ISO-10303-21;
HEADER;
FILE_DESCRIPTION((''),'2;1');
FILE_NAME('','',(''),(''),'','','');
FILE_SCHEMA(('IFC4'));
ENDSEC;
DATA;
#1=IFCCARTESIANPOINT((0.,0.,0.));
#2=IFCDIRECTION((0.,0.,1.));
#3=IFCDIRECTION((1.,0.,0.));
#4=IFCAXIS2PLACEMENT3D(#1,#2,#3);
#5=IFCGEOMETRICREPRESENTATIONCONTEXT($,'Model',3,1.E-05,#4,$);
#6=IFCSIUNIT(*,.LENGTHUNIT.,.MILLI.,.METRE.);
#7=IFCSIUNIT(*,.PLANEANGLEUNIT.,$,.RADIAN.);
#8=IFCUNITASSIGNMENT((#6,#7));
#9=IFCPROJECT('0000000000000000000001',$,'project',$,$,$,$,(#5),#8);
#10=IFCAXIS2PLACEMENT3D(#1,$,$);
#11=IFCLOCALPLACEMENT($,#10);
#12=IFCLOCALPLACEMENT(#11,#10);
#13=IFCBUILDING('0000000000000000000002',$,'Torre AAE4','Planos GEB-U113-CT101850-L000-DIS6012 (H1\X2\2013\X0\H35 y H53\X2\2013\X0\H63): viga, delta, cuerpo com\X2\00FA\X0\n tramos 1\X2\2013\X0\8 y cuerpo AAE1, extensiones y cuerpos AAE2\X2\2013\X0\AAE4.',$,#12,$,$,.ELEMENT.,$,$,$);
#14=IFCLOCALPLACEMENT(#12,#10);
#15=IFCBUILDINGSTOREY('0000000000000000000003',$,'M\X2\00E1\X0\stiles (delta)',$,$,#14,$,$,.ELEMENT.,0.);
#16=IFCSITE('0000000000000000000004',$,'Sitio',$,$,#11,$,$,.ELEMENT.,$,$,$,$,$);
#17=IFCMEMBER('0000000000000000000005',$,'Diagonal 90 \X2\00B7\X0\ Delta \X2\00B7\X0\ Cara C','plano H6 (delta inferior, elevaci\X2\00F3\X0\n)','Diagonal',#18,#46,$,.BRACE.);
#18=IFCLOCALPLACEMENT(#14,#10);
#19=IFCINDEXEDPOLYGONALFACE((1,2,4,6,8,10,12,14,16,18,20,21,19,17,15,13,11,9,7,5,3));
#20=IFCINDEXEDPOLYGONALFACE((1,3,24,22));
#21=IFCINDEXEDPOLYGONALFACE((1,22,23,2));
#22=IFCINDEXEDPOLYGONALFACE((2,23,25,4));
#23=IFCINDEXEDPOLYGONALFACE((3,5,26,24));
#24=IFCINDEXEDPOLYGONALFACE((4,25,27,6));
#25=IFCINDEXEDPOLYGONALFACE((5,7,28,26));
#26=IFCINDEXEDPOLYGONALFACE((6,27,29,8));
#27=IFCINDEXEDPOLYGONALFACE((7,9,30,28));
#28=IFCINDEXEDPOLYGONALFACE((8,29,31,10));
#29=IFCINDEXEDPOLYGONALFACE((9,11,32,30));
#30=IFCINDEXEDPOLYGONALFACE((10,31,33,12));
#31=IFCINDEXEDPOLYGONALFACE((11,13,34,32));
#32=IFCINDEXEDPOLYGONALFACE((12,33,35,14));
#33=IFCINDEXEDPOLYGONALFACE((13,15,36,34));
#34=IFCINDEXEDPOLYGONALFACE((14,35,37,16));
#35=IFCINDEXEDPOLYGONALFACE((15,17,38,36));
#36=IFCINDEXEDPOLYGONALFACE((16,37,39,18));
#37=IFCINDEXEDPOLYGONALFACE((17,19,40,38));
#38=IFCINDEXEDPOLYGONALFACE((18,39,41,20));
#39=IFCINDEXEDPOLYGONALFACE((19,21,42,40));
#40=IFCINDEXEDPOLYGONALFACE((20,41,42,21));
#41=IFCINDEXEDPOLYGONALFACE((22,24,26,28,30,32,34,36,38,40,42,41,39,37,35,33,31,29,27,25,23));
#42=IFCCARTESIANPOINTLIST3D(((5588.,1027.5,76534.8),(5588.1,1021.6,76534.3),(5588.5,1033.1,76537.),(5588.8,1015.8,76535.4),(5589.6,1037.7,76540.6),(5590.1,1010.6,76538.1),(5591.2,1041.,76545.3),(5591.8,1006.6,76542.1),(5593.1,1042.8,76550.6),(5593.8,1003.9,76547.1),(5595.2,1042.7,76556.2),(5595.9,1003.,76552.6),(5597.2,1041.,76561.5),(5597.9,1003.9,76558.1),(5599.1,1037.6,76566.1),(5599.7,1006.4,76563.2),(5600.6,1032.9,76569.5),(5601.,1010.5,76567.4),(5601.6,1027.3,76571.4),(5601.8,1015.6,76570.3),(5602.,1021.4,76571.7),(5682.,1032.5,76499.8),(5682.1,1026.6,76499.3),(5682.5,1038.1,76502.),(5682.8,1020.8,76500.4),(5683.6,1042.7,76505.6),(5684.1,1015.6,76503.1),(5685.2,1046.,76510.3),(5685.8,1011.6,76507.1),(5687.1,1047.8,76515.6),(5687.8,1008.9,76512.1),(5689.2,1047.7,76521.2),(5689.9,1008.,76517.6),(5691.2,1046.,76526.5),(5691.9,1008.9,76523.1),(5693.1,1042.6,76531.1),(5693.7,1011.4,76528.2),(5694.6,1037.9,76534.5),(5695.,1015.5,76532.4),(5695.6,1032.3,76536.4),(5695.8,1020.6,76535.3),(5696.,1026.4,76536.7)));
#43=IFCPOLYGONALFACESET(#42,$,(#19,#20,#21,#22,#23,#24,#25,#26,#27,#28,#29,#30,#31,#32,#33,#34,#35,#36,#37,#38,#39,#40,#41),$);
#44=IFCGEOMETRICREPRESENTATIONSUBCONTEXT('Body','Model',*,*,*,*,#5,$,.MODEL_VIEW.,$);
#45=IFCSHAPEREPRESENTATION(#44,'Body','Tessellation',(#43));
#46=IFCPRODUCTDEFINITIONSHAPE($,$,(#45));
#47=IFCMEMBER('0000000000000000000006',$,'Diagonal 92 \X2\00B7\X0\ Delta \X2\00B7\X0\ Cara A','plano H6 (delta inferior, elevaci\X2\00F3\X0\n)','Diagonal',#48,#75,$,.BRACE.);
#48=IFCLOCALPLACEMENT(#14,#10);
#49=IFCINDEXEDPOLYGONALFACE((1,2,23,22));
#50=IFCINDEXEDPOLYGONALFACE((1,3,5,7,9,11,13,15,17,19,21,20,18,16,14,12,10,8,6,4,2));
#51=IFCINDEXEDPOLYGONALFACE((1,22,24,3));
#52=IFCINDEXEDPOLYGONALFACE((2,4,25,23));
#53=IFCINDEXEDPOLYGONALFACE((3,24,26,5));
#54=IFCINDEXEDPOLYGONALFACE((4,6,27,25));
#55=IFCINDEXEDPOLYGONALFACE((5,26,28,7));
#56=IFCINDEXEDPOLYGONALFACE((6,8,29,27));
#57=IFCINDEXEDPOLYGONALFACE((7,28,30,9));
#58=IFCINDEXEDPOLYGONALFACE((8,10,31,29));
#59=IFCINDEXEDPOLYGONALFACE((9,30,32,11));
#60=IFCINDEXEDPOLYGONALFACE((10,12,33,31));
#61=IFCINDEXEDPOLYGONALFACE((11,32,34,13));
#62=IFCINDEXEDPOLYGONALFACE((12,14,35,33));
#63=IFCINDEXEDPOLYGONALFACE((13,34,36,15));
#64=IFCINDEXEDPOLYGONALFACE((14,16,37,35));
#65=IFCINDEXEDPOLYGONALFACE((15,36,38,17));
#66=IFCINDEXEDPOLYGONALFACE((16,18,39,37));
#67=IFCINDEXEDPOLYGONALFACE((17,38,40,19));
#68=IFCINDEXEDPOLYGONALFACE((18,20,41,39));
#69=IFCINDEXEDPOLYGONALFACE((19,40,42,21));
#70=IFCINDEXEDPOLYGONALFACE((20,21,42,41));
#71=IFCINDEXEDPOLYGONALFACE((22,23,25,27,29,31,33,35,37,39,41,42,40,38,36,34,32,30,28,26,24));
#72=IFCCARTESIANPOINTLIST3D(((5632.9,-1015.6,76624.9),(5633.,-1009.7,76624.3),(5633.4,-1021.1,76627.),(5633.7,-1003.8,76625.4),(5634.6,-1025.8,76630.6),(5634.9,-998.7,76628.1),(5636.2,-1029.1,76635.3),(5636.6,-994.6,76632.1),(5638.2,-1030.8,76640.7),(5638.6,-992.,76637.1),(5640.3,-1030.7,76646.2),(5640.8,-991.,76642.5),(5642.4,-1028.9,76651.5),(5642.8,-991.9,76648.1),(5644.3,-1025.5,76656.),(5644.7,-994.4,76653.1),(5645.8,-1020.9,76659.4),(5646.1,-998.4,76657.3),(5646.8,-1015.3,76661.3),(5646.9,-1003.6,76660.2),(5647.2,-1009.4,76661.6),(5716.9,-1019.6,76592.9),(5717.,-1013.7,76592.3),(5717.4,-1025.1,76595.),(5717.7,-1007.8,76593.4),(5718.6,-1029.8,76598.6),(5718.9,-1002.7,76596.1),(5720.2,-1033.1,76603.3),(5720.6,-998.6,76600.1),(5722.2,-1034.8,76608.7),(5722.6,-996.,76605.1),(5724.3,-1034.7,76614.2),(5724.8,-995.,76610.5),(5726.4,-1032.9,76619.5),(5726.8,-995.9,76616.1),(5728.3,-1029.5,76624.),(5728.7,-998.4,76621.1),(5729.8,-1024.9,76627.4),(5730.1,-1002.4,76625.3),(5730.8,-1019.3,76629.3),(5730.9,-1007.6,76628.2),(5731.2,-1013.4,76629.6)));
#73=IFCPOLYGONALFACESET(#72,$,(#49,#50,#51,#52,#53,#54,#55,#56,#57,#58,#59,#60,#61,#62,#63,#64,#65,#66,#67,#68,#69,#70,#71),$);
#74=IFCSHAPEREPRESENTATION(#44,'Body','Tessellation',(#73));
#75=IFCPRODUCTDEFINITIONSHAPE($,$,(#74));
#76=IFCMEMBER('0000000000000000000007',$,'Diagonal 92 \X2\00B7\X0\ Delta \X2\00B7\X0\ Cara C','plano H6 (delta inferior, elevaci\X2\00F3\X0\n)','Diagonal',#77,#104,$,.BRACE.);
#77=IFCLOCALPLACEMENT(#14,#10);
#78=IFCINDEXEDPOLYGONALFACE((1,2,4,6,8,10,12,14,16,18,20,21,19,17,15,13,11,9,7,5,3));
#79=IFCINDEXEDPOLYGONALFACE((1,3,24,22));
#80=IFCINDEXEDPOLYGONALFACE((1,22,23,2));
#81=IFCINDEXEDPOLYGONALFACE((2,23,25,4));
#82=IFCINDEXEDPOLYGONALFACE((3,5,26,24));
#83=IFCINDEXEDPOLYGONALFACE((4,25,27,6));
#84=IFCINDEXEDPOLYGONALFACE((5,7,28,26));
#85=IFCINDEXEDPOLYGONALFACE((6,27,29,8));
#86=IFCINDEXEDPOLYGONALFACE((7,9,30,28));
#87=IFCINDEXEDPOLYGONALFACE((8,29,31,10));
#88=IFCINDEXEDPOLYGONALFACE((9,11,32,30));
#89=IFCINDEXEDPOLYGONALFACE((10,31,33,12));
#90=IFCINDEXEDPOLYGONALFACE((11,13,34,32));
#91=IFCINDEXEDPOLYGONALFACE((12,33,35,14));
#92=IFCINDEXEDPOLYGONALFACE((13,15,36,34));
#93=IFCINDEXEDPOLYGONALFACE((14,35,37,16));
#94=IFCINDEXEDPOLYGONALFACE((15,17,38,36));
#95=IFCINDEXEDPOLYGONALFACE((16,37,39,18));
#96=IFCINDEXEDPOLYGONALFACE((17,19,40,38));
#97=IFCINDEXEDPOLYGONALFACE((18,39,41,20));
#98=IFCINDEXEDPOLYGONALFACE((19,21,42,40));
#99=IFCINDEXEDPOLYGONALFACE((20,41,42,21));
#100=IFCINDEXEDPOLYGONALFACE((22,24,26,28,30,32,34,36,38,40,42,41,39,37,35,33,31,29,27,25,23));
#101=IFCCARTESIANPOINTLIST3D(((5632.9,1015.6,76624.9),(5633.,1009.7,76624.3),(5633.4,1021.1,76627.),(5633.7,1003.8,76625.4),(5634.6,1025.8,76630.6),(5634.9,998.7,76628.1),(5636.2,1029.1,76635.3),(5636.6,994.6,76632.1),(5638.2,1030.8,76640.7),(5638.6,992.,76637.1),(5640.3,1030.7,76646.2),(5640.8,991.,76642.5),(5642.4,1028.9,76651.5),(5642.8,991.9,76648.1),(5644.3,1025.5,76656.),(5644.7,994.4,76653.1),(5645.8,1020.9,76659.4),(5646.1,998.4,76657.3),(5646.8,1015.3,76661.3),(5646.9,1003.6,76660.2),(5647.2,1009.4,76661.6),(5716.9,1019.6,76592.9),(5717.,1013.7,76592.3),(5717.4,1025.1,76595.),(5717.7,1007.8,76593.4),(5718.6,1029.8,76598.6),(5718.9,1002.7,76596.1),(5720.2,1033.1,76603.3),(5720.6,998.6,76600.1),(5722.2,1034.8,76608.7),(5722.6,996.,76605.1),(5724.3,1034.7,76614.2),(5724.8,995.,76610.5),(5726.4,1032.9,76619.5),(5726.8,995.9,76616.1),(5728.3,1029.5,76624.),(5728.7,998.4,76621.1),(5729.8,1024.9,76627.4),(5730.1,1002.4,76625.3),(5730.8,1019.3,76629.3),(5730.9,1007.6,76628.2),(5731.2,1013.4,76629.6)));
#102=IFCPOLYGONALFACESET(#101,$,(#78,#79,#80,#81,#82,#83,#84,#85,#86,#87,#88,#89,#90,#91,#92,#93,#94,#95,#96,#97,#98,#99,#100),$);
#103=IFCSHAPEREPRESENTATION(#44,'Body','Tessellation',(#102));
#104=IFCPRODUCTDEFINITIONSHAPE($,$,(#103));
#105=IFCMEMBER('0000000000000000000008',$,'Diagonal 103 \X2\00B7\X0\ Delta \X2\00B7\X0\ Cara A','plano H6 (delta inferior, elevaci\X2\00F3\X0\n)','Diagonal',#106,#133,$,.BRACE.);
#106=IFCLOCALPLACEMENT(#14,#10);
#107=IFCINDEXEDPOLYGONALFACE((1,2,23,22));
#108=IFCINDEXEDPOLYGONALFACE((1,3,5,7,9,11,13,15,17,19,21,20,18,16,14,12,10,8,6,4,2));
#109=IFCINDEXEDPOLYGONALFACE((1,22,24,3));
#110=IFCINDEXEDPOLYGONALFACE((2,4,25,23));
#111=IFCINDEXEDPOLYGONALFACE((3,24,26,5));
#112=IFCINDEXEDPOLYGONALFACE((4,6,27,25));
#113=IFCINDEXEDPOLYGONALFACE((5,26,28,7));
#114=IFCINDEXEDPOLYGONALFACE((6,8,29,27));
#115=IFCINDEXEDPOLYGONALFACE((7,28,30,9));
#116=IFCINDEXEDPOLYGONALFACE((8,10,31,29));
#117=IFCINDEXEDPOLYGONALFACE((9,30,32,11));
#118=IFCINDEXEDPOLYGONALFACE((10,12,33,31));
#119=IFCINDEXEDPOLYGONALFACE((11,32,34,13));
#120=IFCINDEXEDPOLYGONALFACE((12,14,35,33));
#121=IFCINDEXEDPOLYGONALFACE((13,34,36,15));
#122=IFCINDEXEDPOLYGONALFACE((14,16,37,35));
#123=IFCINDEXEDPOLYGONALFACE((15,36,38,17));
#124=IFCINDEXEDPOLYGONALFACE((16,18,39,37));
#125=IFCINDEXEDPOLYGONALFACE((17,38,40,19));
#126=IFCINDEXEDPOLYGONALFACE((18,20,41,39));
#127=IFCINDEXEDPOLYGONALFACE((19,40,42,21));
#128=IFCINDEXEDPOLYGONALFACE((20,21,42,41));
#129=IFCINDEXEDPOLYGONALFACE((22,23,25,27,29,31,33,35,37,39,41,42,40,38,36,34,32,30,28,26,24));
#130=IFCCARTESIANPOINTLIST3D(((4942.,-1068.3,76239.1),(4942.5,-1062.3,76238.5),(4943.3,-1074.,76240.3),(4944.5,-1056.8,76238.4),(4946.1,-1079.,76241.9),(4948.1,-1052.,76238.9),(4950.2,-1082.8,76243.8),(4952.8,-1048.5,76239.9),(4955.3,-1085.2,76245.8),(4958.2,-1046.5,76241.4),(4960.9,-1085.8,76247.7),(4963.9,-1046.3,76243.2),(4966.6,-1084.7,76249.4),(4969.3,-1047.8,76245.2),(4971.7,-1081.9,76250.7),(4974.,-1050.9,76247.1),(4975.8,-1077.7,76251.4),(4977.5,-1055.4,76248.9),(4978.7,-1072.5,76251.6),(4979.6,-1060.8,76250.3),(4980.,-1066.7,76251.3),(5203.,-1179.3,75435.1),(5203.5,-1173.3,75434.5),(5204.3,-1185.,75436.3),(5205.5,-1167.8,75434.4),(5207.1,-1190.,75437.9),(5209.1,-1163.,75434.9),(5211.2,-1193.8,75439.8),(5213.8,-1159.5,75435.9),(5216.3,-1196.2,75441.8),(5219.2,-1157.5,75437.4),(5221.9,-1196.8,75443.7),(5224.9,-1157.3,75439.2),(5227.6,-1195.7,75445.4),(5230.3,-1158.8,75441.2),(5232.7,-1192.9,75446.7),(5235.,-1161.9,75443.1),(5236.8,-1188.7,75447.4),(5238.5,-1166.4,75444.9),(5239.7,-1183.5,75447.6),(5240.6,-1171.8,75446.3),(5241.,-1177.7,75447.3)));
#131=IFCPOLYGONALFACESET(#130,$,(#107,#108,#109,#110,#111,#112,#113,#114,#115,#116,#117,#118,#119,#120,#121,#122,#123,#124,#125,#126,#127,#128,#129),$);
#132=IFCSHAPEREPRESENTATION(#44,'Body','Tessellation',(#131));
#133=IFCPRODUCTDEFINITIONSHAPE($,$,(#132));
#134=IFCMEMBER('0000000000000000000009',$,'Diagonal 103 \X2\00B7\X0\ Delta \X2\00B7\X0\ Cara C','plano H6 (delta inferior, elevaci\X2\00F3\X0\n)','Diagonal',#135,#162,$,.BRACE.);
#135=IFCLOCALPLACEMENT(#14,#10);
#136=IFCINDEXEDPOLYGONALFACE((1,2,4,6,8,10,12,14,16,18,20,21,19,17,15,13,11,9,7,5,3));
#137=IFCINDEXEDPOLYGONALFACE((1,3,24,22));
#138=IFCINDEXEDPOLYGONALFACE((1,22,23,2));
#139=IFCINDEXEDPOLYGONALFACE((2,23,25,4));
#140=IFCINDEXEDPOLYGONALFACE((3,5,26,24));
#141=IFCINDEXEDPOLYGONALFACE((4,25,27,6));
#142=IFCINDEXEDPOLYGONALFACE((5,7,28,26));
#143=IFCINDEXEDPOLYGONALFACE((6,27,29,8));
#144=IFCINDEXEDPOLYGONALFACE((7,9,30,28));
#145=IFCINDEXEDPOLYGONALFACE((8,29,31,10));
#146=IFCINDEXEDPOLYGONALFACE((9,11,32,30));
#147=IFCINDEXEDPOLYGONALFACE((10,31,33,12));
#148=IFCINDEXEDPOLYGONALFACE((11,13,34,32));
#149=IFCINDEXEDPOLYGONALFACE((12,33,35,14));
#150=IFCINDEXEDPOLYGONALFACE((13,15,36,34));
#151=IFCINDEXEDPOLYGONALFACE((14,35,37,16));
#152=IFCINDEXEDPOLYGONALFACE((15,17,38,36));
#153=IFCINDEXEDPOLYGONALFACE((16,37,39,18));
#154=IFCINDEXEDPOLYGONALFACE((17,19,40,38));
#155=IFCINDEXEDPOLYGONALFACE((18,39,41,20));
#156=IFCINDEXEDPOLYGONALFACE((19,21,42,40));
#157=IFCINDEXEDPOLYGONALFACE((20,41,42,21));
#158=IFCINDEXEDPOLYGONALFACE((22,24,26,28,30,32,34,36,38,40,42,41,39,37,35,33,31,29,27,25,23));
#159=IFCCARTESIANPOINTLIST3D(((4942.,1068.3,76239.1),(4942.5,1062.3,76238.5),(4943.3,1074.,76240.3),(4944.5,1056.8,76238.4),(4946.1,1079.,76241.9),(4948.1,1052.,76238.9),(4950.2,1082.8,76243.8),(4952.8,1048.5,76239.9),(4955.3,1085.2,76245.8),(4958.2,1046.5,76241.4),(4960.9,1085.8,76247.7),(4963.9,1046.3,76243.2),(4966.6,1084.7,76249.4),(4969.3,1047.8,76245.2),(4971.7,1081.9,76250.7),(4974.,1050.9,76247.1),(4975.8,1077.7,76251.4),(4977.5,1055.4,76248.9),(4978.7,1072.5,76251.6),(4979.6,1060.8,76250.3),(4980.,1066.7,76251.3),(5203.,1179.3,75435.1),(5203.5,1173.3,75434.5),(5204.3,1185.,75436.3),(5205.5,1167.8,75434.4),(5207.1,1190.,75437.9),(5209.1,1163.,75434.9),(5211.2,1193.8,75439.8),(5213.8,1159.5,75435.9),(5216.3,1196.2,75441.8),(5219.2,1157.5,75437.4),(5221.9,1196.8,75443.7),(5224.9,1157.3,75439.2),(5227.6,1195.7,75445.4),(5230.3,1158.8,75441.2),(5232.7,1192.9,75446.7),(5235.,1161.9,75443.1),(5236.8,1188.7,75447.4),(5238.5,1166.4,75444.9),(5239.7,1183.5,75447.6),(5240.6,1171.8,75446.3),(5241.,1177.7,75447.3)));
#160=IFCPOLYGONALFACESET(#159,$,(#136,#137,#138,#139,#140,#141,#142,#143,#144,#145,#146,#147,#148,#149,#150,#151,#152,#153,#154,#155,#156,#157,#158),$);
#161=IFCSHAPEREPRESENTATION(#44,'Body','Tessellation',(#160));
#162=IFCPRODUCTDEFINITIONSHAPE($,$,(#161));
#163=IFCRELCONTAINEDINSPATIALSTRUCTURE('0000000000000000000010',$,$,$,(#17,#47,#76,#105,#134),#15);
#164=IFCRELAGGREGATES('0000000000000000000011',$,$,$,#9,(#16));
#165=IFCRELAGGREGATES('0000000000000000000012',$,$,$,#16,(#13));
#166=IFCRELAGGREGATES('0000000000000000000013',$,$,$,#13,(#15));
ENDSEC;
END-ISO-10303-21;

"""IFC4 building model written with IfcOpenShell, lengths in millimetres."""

from ifc_helpers import new_model, si_unit, frame, origin, origin_with_axes, place, context, subcontext, project, spatial, circle, extrude, element, save


model = new_model("IFC4")

# Units and contexts
model_context = context("Model", 3, precision=1e-05, world=origin_with_axes())
body_context = subcontext(model_context, "Body", "Model", "MODEL_VIEW")
ifc_project = project(units=[si_unit("LENGTHUNIT", "METRE", prefix="MILLI"), si_unit("PLANEANGLEUNIT", "RADIAN")], contexts=[model_context])

# Site, building, storey
site_placement = place(None, origin())
site = spatial("IfcSite", under=ifc_project, at=site_placement, Name="Sitio", CompositionType="ELEMENT")
building_placement = place(site_placement, origin())
building = spatial("IfcBuilding", under=site, at=building_placement, Name="Torre AAE4", Description="Planos GEB-U113-CT101850-L000-DIS6012 (H1–H35 y H53–H63): viga, delta, cuerpo común tramos 1–8 y cuerpo AAE1, extensiones y cuerpos AAE2–AAE4.", CompositionType="ELEMENT")
storey_placement = place(building_placement, origin())
storey = spatial("IfcBuildingStorey", under=building, at=storey_placement, Name="Mástiles (delta)", CompositionType="ELEMENT", Elevation=0.0)

# Members
for number, where, z_axis, x_axis, name in (
    (1, (5595.0, 1023.0, 76553.0), (0.935984, 0.049786, -0.348505), (-0.308647, -0.360098, -0.880379), "Diagonal 90 · Delta · Cara C"),
):
    element("IfcMember", number, at=place(storey_placement, frame(where, z_axis=z_axis, x_axis=x_axis)), inside=storey, Name=name, Description="plano H6 (delta inferior, elevación)", ObjectType="Diagonal", PredefinedType="BRACE", context=body_context, shape_type="SweptSolid", body=[
        extrude(circle(Radius=20.0), None, (0.0, 0.0, 1.0), 100.4),
    ])
for number, where, z_axis, x_axis, name in (
    (2, (5640.0, -1011.0, 76643.0), (0.933564, -0.044455, -0.355643), (-0.3175, 0.357806, -0.878162), "Diagonal 92 · Delta · Cara A"),
    (3, (5640.0, 1011.0, 76643.0), (0.933564, 0.044455, -0.355643), (-0.3175, -0.357806, -0.878162), "Diagonal 92 · Delta · Cara C"),
):
    element("IfcMember", number, at=place(storey_placement, frame(where, z_axis=z_axis, x_axis=x_axis)), inside=storey, Name=name, Description="plano H6 (delta inferior, elevación)", ObjectType="Diagonal", PredefinedType="BRACE", context=body_context, shape_type="SweptSolid", body=[
        extrude(circle(Radius=20.0), None, (0.0, 0.0, 1.0), 90.0),
    ])
for number, where, z_axis, x_axis, name in (
    (4, (5222.0, -1177.0, 75441.0), (-0.306137, 0.130196, 0.943042), (-0.92747, 0.182577, -0.326288), "Diagonal 103 · Delta · Cara A"),
    (5, (5222.0, 1177.0, 75441.0), (-0.306137, -0.130196, 0.943042), (-0.92747, -0.182577, -0.326288), "Diagonal 103 · Delta · Cara C"),
):
    element("IfcMember", number, at=place(storey_placement, frame(where, z_axis=z_axis, x_axis=x_axis)), inside=storey, Name=name, Description="plano H6 (delta inferior, elevación)", ObjectType="Diagonal", PredefinedType="BRACE", context=body_context, shape_type="SweptSolid", body=[
        extrude(circle(Radius=20.0), None, (0.0, 0.0, 1.0), 852.6),
    ])

save(model, "model.ifc")
